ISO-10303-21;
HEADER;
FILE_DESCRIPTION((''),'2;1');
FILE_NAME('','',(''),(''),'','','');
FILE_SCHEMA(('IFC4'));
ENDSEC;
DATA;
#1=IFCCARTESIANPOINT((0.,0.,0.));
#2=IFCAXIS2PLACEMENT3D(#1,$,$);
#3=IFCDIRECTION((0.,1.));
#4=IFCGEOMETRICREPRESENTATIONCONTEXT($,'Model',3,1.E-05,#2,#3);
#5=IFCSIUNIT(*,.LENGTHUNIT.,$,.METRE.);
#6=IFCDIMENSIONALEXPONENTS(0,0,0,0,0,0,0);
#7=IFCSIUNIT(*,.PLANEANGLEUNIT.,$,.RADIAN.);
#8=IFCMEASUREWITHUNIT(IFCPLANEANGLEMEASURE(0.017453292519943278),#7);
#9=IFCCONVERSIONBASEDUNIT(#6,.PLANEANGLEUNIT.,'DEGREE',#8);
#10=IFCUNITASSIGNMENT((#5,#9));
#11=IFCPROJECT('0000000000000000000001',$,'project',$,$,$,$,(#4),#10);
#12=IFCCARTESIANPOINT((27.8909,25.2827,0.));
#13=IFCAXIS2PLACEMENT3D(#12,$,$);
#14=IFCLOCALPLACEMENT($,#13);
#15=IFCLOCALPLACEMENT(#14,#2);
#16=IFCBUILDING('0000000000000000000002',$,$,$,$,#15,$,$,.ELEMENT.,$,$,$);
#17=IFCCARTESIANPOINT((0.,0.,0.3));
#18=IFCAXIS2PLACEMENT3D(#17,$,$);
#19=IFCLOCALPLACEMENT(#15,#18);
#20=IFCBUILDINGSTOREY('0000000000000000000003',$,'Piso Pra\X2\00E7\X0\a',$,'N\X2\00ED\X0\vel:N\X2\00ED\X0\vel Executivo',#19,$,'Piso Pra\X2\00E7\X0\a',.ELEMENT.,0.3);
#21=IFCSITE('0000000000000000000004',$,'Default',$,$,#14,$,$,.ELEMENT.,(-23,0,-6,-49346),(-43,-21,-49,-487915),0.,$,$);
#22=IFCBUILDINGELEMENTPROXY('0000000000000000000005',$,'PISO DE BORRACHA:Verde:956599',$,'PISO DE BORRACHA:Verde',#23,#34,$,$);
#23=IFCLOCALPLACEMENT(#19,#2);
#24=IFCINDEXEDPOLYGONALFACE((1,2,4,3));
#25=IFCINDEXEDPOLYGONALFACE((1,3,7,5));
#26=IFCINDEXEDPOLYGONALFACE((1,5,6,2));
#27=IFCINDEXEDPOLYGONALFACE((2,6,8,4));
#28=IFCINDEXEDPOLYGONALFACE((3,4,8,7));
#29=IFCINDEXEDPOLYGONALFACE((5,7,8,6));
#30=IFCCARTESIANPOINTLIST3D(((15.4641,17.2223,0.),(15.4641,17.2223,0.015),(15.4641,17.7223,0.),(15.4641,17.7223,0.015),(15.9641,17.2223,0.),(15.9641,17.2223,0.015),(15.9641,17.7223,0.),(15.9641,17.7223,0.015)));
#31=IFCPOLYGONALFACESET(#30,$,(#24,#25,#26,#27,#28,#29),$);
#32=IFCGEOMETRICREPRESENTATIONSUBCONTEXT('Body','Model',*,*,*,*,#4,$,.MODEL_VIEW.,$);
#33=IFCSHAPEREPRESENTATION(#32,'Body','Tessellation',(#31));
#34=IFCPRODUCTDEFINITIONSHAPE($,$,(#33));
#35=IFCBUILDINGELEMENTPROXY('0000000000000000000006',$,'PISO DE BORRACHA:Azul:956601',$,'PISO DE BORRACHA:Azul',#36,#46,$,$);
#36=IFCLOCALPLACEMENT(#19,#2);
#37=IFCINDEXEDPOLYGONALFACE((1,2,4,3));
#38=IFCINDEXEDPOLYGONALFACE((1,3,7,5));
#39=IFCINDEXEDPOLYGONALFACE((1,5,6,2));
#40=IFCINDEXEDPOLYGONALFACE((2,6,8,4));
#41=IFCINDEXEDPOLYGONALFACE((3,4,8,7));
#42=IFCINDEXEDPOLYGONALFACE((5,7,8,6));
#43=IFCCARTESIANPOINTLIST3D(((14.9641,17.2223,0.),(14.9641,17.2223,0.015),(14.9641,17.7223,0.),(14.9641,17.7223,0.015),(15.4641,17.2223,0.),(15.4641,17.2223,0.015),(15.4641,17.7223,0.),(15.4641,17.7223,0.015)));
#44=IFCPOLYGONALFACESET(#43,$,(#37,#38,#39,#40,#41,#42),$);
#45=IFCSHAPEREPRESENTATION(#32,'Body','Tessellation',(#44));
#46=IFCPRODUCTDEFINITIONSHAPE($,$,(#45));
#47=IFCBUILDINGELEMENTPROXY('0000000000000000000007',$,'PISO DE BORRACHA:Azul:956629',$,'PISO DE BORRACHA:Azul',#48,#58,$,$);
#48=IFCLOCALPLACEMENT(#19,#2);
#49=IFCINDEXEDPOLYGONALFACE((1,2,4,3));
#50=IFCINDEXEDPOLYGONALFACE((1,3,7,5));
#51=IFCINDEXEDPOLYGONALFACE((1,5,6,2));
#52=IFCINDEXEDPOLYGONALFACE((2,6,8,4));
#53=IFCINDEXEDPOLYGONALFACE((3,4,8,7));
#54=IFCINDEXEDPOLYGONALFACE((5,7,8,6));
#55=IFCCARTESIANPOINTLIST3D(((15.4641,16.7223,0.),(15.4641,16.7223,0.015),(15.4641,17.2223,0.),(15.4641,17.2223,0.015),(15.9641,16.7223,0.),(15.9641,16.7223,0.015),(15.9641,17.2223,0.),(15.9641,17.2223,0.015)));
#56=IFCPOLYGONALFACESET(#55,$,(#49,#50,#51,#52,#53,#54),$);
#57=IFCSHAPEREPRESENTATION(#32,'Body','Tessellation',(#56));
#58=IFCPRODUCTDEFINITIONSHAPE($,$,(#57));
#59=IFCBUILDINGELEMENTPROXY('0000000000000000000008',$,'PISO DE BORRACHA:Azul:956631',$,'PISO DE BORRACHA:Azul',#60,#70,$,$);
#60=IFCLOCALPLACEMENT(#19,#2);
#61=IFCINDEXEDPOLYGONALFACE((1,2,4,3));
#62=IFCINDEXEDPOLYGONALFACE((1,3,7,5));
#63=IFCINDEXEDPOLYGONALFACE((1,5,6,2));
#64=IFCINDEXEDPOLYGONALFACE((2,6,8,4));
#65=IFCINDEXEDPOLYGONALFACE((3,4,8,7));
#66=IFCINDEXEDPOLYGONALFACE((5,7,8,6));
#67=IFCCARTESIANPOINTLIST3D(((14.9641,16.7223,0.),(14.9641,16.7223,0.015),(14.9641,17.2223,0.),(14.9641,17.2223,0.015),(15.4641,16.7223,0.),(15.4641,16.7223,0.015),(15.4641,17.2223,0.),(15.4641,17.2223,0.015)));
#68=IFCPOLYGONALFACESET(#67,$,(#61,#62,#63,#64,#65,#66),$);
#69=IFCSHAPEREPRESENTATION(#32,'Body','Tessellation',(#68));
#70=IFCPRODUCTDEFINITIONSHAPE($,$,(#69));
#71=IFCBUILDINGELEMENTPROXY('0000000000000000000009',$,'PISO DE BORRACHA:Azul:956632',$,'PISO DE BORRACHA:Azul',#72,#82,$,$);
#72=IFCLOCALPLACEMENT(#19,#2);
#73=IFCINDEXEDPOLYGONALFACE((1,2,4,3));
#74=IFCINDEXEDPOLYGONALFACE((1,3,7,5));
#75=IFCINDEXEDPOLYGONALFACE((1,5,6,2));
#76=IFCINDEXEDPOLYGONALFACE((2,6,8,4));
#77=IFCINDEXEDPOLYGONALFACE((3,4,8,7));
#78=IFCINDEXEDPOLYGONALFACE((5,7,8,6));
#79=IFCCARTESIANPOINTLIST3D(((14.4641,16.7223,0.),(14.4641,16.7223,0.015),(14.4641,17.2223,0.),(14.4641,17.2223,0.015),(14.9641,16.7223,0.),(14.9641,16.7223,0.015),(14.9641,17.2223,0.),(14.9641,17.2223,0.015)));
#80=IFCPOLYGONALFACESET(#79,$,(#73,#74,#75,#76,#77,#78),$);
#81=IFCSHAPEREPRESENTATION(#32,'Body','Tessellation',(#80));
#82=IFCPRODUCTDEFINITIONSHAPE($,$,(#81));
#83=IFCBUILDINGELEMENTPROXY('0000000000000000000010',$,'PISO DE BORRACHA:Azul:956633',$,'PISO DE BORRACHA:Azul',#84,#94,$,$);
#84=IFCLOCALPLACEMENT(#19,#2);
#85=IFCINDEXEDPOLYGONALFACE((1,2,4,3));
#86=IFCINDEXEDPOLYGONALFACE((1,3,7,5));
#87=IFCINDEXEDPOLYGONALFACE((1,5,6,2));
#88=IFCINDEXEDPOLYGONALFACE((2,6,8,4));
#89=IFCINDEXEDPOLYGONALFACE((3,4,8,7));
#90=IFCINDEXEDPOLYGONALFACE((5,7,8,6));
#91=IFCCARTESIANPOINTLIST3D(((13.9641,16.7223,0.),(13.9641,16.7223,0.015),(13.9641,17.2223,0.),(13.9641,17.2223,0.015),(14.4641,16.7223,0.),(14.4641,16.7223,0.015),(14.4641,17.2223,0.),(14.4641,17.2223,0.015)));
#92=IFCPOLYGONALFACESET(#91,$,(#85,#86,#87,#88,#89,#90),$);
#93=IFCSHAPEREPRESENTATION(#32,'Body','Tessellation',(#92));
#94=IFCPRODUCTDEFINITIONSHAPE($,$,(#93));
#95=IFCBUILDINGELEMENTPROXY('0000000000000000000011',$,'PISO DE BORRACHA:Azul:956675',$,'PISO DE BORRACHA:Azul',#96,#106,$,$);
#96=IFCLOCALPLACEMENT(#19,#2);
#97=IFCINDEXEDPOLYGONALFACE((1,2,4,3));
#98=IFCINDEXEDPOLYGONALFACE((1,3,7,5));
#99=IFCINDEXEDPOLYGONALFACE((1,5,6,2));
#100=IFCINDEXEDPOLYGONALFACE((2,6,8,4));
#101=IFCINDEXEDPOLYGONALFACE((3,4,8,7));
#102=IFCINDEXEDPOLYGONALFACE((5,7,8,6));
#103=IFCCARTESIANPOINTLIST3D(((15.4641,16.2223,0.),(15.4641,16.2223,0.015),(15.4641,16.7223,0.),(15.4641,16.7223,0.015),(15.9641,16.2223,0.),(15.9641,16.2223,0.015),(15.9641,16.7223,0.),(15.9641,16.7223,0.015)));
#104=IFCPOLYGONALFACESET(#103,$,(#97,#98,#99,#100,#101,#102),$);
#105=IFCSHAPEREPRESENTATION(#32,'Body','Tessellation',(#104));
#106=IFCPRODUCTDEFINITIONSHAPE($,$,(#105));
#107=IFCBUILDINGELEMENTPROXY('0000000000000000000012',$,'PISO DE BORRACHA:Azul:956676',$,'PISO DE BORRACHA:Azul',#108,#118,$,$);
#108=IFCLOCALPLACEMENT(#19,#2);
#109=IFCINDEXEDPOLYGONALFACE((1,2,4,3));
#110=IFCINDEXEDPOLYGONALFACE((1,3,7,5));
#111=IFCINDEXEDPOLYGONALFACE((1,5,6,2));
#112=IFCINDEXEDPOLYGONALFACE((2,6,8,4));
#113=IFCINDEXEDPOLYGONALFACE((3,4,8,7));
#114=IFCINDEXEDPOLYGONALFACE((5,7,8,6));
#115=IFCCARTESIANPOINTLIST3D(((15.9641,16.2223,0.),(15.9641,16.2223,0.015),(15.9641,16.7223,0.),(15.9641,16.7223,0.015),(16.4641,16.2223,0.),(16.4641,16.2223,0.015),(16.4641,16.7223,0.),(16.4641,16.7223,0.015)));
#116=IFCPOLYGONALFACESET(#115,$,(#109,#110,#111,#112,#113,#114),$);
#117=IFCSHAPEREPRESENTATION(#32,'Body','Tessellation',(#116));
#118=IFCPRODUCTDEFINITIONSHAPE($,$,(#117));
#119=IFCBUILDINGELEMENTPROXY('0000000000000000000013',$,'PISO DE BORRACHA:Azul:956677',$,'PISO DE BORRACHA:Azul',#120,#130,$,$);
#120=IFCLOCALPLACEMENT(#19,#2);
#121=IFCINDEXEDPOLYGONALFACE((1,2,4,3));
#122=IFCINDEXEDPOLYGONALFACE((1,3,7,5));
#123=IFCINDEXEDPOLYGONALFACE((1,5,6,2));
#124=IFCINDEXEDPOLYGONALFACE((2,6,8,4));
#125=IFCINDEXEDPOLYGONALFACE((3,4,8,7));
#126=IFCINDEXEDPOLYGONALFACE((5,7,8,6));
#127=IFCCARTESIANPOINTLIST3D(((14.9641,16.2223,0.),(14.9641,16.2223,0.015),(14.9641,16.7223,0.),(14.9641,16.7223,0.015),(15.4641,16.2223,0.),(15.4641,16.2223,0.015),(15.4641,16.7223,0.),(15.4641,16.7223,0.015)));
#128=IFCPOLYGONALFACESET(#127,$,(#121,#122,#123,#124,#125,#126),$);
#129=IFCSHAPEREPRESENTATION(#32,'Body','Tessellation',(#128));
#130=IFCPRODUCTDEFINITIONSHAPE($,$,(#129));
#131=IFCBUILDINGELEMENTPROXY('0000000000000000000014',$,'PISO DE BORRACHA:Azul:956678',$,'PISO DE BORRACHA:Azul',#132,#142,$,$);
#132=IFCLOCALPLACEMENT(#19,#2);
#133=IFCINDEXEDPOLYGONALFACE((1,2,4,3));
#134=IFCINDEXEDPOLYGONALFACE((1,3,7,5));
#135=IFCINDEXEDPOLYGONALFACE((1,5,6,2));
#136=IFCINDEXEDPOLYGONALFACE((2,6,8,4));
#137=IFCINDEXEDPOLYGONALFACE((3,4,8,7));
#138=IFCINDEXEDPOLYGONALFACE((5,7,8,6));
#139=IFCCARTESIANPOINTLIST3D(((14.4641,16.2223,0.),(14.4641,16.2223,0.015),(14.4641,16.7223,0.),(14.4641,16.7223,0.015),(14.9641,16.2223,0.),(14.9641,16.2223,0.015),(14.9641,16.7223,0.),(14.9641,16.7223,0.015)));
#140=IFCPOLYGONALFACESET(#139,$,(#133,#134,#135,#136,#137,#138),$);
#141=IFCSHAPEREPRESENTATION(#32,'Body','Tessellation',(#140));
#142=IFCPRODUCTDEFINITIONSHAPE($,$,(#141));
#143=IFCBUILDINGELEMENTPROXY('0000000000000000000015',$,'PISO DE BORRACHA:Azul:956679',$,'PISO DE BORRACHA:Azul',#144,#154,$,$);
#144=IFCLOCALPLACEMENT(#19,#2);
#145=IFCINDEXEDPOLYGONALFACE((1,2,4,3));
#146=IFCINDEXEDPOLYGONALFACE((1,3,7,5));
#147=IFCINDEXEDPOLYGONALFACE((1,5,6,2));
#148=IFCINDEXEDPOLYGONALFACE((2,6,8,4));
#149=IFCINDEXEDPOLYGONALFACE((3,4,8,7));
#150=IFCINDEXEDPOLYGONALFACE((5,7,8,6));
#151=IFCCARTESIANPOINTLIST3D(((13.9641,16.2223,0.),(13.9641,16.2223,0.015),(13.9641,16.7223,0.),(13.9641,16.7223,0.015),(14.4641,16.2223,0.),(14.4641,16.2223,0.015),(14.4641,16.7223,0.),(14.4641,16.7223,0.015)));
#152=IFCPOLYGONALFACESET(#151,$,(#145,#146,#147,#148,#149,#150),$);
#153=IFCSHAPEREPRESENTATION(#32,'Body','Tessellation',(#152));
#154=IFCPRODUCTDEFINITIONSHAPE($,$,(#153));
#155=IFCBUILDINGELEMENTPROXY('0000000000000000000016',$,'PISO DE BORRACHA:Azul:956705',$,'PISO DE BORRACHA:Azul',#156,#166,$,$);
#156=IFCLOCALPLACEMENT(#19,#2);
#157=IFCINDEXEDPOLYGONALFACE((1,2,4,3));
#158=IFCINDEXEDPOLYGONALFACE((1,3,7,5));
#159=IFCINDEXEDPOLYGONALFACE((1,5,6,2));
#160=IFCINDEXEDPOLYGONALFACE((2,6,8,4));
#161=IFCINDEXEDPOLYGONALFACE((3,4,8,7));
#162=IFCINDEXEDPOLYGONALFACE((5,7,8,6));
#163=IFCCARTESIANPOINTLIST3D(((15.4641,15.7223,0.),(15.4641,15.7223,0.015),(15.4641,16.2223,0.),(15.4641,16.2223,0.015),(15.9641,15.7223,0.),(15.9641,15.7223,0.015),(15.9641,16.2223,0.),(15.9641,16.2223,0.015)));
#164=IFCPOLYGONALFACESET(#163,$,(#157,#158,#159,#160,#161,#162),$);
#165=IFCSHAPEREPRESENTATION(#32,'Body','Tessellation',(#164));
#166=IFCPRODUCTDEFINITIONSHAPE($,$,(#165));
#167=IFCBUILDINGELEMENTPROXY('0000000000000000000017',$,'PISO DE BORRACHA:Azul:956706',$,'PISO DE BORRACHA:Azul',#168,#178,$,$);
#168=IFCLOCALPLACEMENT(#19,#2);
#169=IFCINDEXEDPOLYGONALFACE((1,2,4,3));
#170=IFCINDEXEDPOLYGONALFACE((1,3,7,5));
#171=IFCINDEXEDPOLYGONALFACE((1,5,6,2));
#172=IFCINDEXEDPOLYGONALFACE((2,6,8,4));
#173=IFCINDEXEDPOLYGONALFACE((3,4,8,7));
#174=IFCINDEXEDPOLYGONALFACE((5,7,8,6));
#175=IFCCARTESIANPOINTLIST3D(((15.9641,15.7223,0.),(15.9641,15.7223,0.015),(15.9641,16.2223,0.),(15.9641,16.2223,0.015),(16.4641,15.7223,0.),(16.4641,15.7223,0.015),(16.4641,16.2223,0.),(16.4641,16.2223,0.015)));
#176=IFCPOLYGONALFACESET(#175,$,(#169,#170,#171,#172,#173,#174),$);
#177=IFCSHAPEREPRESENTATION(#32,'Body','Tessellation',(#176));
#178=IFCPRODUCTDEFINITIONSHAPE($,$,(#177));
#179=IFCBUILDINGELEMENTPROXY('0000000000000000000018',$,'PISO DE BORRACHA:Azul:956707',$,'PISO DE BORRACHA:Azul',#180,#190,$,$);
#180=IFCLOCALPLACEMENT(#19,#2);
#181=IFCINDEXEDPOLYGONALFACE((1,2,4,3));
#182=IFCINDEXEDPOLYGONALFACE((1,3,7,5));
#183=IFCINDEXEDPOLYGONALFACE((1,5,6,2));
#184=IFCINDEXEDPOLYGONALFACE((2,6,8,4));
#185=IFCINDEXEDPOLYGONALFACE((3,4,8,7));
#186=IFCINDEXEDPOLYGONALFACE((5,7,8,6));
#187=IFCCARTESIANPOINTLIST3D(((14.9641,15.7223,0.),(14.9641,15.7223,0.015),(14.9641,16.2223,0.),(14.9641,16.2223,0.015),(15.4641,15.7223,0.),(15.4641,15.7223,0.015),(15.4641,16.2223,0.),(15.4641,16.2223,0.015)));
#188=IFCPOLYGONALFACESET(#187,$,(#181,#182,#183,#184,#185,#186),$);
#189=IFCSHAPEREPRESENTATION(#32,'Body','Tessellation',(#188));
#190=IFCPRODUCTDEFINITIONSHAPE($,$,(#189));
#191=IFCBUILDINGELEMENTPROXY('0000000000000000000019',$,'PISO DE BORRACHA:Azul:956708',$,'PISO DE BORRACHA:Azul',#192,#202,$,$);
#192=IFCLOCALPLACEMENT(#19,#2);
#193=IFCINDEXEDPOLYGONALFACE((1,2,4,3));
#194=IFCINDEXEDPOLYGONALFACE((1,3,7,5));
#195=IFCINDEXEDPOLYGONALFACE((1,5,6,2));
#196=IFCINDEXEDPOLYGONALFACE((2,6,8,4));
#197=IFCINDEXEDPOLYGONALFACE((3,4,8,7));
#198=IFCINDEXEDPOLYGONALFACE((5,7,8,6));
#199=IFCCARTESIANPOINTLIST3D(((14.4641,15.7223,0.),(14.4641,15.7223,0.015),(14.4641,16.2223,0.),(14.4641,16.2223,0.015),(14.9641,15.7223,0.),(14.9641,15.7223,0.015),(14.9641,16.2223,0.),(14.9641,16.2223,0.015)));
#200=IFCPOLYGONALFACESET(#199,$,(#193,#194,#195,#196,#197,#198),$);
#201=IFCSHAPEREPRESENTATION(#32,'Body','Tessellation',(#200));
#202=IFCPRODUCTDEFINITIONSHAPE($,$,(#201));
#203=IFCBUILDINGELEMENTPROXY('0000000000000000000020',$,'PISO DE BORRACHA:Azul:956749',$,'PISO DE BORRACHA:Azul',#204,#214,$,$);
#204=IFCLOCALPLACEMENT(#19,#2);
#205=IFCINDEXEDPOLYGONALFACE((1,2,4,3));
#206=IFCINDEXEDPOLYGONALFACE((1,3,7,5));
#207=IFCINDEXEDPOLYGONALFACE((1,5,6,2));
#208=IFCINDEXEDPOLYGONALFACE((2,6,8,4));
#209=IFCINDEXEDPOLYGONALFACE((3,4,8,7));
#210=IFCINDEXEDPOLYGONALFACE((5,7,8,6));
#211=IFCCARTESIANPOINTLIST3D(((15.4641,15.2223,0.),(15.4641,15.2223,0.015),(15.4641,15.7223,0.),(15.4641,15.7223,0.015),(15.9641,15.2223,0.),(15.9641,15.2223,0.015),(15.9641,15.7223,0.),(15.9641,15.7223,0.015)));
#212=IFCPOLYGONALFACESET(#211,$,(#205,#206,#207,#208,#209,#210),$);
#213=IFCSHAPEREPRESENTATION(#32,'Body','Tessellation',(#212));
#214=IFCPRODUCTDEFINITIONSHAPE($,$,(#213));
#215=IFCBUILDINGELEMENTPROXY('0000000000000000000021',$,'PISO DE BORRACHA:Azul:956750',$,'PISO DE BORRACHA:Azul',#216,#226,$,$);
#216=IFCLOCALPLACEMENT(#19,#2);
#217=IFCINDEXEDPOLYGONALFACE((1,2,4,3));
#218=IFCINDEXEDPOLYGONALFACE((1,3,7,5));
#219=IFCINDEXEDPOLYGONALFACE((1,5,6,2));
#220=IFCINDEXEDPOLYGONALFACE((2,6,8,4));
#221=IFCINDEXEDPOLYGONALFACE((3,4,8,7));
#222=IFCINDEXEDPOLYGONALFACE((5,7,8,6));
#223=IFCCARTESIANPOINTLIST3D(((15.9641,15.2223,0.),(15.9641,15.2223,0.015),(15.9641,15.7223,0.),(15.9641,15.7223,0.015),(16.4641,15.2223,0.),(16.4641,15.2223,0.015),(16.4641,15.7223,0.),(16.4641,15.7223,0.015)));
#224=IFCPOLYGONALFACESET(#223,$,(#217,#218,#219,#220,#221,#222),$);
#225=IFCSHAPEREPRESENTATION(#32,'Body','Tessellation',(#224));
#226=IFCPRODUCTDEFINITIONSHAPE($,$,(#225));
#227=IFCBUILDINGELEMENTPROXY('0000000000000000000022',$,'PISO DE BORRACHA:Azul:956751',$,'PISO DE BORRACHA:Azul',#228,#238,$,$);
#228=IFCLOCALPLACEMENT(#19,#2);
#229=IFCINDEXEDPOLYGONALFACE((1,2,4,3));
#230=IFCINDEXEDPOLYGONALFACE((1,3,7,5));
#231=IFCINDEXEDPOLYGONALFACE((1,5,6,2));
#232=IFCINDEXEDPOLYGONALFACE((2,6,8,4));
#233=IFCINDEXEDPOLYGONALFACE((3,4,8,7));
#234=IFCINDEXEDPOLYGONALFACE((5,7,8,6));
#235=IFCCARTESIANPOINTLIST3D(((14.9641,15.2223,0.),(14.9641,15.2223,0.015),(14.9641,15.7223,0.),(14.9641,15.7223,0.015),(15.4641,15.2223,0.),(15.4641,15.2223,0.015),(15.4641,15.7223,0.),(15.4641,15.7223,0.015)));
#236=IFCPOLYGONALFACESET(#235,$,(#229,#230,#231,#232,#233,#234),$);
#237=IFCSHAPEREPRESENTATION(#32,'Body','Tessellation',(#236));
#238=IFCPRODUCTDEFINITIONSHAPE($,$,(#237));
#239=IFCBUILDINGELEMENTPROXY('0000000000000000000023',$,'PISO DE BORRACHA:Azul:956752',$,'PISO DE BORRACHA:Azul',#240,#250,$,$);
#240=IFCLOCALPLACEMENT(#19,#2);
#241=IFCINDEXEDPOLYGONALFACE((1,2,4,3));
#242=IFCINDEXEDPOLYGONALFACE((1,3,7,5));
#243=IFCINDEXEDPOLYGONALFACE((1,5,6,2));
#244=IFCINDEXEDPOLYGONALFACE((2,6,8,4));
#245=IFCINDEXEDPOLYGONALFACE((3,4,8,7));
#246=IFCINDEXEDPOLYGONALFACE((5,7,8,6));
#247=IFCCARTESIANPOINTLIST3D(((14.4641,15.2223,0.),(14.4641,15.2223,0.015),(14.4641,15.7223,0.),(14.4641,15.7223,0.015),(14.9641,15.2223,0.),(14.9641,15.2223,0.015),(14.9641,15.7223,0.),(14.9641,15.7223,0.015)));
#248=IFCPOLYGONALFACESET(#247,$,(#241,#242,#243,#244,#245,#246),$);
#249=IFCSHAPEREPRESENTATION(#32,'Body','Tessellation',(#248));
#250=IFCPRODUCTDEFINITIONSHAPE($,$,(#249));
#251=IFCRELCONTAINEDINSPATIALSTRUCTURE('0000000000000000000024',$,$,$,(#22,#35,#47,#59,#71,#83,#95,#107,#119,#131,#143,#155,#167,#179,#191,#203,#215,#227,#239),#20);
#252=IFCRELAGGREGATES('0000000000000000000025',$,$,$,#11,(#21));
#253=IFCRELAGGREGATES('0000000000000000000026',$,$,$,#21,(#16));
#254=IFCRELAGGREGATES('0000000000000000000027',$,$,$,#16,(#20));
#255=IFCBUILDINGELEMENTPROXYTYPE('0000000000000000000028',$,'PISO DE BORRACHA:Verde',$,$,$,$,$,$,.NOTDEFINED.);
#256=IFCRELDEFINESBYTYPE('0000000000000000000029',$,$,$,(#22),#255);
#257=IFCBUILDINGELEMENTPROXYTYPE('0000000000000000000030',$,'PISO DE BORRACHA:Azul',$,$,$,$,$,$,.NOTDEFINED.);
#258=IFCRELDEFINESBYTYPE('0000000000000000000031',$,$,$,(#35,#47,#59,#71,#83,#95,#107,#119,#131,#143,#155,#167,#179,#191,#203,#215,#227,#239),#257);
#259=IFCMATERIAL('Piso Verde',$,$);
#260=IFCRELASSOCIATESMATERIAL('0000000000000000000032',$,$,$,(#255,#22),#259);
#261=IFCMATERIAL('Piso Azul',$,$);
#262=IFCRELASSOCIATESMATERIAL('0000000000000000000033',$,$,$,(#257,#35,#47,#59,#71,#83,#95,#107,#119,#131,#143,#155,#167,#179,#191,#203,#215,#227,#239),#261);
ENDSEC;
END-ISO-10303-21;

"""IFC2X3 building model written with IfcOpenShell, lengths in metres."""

from ifc_helpers import new_model, entity, si_unit, converted_unit, direction, frame, origin, origin_2d_with_axis, place, context, subcontext, project, spatial, rectangle, extrude, source, transform, mapped, material, type_object, type_shapes, element, save


model = new_model("IFC2X3")

# Units and contexts
model_context = context("Model", 3, precision=1e-05, world=origin(), true_north=direction((0.0, 1.0)))
body_context = subcontext(model_context, "Body", "Model", "MODEL_VIEW")
ifc_project = project(units=[si_unit("LENGTHUNIT", "METRE"), converted_unit("PLANEANGLEUNIT", "DEGREE", entity("IfcPlaneAngleMeasure", 0.017453292519943278), si_unit("PLANEANGLEUNIT", "RADIAN"), dimensions=[0, 0, 0, 0, 0, 0, 0])], contexts=[model_context])

# Site, building, storey
site_placement = place(None, frame((27.8909, 25.2827, 0.0)))
site = spatial("IfcSite", under=ifc_project, at=site_placement, Name="Default", CompositionType="ELEMENT", RefLatitude=(-23, 0, -6, -49346), RefLongitude=(-43, -21, -49, -487915), RefElevation=0.0)
building_placement = place(site_placement, origin())
building = spatial("IfcBuilding", under=site, at=building_placement, CompositionType="ELEMENT")
storey_placement = place(building_placement, frame((0.0, 0.0, 0.3)))
storey = spatial("IfcBuildingStorey", under=building, at=storey_placement, Name="Piso Praça", ObjectType="Nível:Nível Executivo", LongName="Piso Praça", CompositionType="ELEMENT", Elevation=0.3)

# Building element proxies
ifc_material_1 = material(Name="Piso Verde")
building_element_proxy_type_1 = type_object("IfcBuildingElementProxyType", Name="PISO DE BORRACHA:Verde", PredefinedType="NOTDEFINED", material=ifc_material_1)
shared_shape_1 = source(origin(), body_context, "Body", "SweptSolid", [
    extrude(rectangle(XDim=0.5, YDim=0.5, at=origin_2d_with_axis()), frame((0.25, 0.25, 0.0), z_axis=(0.0, 0.0, 1.0), x_axis=(-1.0, 0.0, 0.0)), (0.0, 0.0, 1.0), 0.015),
])
type_shapes(building_element_proxy_type_1, [shared_shape_1])
proxy_placement = place(storey_placement, frame((15.4641, 17.2223, 0.0)))
element("IfcBuildingElementProxy", 1, at=proxy_placement, inside=storey, type_object=building_element_proxy_type_1, material=ifc_material_1, Name="PISO DE BORRACHA:Verde:956599", ObjectType="PISO DE BORRACHA:Verde", context=body_context, shape_type="MappedRepresentation", body=[
    mapped(shared_shape_1, transform((0.0, 0.0, 0.0), scale=1.0)),
])
ifc_material_2 = material(Name="Piso Azul")
building_element_proxy_type_2 = type_object("IfcBuildingElementProxyType", Name="PISO DE BORRACHA:Azul", PredefinedType="NOTDEFINED", material=ifc_material_2)
shared_shape_2 = source(origin(), body_context, "Body", "SweptSolid", [
    extrude(rectangle(XDim=0.5, YDim=0.5, at=origin_2d_with_axis()), frame((0.25, 0.25, 0.0), z_axis=(0.0, 0.0, 1.0), x_axis=(-1.0, 0.0, 0.0)), (0.0, 0.0, 1.0), 0.015),
])
type_shapes(building_element_proxy_type_2, [shared_shape_2])
for number, where, name in (
    (2, (14.9641, 17.2223, 0.0), "PISO DE BORRACHA:Azul:956601"),
    (3, (15.4641, 16.7223, 0.0), "PISO DE BORRACHA:Azul:956629"),
    (4, (14.9641, 16.7223, 0.0), "PISO DE BORRACHA:Azul:956631"),
    (5, (14.4641, 16.7223, 0.0), "PISO DE BORRACHA:Azul:956632"),
    (6, (13.9641, 16.7223, 0.0), "PISO DE BORRACHA:Azul:956633"),
    (7, (15.4641, 16.2223, 0.0), "PISO DE BORRACHA:Azul:956675"),
    (8, (15.9641, 16.2223, 0.0), "PISO DE BORRACHA:Azul:956676"),
    (9, (14.9641, 16.2223, 0.0), "PISO DE BORRACHA:Azul:956677"),
    (10, (14.4641, 16.2223, 0.0), "PISO DE BORRACHA:Azul:956678"),
    (11, (13.9641, 16.2223, 0.0), "PISO DE BORRACHA:Azul:956679"),
    (12, (15.4641, 15.7223, 0.0), "PISO DE BORRACHA:Azul:956705"),
    (13, (15.9641, 15.7223, 0.0), "PISO DE BORRACHA:Azul:956706"),
    (14, (14.9641, 15.7223, 0.0), "PISO DE BORRACHA:Azul:956707"),
    (15, (14.4641, 15.7223, 0.0), "PISO DE BORRACHA:Azul:956708"),
    (16, (15.4641, 15.2223, 0.0), "PISO DE BORRACHA:Azul:956749"),
    (17, (15.9641, 15.2223, 0.0), "PISO DE BORRACHA:Azul:956750"),
    (18, (14.9641, 15.2223, 0.0), "PISO DE BORRACHA:Azul:956751"),
    (19, (14.4641, 15.2223, 0.0), "PISO DE BORRACHA:Azul:956752"),
):
    element("IfcBuildingElementProxy", number, at=place(storey_placement, frame(where)), inside=storey, type_object=building_element_proxy_type_2, material=ifc_material_2, Name=name, ObjectType="PISO DE BORRACHA:Azul", context=body_context, shape_type="MappedRepresentation", body=[
        mapped(shared_shape_2, transform((0.0, 0.0, 0.0), scale=1.0)),
    ])

save(model, "model.ifc")
